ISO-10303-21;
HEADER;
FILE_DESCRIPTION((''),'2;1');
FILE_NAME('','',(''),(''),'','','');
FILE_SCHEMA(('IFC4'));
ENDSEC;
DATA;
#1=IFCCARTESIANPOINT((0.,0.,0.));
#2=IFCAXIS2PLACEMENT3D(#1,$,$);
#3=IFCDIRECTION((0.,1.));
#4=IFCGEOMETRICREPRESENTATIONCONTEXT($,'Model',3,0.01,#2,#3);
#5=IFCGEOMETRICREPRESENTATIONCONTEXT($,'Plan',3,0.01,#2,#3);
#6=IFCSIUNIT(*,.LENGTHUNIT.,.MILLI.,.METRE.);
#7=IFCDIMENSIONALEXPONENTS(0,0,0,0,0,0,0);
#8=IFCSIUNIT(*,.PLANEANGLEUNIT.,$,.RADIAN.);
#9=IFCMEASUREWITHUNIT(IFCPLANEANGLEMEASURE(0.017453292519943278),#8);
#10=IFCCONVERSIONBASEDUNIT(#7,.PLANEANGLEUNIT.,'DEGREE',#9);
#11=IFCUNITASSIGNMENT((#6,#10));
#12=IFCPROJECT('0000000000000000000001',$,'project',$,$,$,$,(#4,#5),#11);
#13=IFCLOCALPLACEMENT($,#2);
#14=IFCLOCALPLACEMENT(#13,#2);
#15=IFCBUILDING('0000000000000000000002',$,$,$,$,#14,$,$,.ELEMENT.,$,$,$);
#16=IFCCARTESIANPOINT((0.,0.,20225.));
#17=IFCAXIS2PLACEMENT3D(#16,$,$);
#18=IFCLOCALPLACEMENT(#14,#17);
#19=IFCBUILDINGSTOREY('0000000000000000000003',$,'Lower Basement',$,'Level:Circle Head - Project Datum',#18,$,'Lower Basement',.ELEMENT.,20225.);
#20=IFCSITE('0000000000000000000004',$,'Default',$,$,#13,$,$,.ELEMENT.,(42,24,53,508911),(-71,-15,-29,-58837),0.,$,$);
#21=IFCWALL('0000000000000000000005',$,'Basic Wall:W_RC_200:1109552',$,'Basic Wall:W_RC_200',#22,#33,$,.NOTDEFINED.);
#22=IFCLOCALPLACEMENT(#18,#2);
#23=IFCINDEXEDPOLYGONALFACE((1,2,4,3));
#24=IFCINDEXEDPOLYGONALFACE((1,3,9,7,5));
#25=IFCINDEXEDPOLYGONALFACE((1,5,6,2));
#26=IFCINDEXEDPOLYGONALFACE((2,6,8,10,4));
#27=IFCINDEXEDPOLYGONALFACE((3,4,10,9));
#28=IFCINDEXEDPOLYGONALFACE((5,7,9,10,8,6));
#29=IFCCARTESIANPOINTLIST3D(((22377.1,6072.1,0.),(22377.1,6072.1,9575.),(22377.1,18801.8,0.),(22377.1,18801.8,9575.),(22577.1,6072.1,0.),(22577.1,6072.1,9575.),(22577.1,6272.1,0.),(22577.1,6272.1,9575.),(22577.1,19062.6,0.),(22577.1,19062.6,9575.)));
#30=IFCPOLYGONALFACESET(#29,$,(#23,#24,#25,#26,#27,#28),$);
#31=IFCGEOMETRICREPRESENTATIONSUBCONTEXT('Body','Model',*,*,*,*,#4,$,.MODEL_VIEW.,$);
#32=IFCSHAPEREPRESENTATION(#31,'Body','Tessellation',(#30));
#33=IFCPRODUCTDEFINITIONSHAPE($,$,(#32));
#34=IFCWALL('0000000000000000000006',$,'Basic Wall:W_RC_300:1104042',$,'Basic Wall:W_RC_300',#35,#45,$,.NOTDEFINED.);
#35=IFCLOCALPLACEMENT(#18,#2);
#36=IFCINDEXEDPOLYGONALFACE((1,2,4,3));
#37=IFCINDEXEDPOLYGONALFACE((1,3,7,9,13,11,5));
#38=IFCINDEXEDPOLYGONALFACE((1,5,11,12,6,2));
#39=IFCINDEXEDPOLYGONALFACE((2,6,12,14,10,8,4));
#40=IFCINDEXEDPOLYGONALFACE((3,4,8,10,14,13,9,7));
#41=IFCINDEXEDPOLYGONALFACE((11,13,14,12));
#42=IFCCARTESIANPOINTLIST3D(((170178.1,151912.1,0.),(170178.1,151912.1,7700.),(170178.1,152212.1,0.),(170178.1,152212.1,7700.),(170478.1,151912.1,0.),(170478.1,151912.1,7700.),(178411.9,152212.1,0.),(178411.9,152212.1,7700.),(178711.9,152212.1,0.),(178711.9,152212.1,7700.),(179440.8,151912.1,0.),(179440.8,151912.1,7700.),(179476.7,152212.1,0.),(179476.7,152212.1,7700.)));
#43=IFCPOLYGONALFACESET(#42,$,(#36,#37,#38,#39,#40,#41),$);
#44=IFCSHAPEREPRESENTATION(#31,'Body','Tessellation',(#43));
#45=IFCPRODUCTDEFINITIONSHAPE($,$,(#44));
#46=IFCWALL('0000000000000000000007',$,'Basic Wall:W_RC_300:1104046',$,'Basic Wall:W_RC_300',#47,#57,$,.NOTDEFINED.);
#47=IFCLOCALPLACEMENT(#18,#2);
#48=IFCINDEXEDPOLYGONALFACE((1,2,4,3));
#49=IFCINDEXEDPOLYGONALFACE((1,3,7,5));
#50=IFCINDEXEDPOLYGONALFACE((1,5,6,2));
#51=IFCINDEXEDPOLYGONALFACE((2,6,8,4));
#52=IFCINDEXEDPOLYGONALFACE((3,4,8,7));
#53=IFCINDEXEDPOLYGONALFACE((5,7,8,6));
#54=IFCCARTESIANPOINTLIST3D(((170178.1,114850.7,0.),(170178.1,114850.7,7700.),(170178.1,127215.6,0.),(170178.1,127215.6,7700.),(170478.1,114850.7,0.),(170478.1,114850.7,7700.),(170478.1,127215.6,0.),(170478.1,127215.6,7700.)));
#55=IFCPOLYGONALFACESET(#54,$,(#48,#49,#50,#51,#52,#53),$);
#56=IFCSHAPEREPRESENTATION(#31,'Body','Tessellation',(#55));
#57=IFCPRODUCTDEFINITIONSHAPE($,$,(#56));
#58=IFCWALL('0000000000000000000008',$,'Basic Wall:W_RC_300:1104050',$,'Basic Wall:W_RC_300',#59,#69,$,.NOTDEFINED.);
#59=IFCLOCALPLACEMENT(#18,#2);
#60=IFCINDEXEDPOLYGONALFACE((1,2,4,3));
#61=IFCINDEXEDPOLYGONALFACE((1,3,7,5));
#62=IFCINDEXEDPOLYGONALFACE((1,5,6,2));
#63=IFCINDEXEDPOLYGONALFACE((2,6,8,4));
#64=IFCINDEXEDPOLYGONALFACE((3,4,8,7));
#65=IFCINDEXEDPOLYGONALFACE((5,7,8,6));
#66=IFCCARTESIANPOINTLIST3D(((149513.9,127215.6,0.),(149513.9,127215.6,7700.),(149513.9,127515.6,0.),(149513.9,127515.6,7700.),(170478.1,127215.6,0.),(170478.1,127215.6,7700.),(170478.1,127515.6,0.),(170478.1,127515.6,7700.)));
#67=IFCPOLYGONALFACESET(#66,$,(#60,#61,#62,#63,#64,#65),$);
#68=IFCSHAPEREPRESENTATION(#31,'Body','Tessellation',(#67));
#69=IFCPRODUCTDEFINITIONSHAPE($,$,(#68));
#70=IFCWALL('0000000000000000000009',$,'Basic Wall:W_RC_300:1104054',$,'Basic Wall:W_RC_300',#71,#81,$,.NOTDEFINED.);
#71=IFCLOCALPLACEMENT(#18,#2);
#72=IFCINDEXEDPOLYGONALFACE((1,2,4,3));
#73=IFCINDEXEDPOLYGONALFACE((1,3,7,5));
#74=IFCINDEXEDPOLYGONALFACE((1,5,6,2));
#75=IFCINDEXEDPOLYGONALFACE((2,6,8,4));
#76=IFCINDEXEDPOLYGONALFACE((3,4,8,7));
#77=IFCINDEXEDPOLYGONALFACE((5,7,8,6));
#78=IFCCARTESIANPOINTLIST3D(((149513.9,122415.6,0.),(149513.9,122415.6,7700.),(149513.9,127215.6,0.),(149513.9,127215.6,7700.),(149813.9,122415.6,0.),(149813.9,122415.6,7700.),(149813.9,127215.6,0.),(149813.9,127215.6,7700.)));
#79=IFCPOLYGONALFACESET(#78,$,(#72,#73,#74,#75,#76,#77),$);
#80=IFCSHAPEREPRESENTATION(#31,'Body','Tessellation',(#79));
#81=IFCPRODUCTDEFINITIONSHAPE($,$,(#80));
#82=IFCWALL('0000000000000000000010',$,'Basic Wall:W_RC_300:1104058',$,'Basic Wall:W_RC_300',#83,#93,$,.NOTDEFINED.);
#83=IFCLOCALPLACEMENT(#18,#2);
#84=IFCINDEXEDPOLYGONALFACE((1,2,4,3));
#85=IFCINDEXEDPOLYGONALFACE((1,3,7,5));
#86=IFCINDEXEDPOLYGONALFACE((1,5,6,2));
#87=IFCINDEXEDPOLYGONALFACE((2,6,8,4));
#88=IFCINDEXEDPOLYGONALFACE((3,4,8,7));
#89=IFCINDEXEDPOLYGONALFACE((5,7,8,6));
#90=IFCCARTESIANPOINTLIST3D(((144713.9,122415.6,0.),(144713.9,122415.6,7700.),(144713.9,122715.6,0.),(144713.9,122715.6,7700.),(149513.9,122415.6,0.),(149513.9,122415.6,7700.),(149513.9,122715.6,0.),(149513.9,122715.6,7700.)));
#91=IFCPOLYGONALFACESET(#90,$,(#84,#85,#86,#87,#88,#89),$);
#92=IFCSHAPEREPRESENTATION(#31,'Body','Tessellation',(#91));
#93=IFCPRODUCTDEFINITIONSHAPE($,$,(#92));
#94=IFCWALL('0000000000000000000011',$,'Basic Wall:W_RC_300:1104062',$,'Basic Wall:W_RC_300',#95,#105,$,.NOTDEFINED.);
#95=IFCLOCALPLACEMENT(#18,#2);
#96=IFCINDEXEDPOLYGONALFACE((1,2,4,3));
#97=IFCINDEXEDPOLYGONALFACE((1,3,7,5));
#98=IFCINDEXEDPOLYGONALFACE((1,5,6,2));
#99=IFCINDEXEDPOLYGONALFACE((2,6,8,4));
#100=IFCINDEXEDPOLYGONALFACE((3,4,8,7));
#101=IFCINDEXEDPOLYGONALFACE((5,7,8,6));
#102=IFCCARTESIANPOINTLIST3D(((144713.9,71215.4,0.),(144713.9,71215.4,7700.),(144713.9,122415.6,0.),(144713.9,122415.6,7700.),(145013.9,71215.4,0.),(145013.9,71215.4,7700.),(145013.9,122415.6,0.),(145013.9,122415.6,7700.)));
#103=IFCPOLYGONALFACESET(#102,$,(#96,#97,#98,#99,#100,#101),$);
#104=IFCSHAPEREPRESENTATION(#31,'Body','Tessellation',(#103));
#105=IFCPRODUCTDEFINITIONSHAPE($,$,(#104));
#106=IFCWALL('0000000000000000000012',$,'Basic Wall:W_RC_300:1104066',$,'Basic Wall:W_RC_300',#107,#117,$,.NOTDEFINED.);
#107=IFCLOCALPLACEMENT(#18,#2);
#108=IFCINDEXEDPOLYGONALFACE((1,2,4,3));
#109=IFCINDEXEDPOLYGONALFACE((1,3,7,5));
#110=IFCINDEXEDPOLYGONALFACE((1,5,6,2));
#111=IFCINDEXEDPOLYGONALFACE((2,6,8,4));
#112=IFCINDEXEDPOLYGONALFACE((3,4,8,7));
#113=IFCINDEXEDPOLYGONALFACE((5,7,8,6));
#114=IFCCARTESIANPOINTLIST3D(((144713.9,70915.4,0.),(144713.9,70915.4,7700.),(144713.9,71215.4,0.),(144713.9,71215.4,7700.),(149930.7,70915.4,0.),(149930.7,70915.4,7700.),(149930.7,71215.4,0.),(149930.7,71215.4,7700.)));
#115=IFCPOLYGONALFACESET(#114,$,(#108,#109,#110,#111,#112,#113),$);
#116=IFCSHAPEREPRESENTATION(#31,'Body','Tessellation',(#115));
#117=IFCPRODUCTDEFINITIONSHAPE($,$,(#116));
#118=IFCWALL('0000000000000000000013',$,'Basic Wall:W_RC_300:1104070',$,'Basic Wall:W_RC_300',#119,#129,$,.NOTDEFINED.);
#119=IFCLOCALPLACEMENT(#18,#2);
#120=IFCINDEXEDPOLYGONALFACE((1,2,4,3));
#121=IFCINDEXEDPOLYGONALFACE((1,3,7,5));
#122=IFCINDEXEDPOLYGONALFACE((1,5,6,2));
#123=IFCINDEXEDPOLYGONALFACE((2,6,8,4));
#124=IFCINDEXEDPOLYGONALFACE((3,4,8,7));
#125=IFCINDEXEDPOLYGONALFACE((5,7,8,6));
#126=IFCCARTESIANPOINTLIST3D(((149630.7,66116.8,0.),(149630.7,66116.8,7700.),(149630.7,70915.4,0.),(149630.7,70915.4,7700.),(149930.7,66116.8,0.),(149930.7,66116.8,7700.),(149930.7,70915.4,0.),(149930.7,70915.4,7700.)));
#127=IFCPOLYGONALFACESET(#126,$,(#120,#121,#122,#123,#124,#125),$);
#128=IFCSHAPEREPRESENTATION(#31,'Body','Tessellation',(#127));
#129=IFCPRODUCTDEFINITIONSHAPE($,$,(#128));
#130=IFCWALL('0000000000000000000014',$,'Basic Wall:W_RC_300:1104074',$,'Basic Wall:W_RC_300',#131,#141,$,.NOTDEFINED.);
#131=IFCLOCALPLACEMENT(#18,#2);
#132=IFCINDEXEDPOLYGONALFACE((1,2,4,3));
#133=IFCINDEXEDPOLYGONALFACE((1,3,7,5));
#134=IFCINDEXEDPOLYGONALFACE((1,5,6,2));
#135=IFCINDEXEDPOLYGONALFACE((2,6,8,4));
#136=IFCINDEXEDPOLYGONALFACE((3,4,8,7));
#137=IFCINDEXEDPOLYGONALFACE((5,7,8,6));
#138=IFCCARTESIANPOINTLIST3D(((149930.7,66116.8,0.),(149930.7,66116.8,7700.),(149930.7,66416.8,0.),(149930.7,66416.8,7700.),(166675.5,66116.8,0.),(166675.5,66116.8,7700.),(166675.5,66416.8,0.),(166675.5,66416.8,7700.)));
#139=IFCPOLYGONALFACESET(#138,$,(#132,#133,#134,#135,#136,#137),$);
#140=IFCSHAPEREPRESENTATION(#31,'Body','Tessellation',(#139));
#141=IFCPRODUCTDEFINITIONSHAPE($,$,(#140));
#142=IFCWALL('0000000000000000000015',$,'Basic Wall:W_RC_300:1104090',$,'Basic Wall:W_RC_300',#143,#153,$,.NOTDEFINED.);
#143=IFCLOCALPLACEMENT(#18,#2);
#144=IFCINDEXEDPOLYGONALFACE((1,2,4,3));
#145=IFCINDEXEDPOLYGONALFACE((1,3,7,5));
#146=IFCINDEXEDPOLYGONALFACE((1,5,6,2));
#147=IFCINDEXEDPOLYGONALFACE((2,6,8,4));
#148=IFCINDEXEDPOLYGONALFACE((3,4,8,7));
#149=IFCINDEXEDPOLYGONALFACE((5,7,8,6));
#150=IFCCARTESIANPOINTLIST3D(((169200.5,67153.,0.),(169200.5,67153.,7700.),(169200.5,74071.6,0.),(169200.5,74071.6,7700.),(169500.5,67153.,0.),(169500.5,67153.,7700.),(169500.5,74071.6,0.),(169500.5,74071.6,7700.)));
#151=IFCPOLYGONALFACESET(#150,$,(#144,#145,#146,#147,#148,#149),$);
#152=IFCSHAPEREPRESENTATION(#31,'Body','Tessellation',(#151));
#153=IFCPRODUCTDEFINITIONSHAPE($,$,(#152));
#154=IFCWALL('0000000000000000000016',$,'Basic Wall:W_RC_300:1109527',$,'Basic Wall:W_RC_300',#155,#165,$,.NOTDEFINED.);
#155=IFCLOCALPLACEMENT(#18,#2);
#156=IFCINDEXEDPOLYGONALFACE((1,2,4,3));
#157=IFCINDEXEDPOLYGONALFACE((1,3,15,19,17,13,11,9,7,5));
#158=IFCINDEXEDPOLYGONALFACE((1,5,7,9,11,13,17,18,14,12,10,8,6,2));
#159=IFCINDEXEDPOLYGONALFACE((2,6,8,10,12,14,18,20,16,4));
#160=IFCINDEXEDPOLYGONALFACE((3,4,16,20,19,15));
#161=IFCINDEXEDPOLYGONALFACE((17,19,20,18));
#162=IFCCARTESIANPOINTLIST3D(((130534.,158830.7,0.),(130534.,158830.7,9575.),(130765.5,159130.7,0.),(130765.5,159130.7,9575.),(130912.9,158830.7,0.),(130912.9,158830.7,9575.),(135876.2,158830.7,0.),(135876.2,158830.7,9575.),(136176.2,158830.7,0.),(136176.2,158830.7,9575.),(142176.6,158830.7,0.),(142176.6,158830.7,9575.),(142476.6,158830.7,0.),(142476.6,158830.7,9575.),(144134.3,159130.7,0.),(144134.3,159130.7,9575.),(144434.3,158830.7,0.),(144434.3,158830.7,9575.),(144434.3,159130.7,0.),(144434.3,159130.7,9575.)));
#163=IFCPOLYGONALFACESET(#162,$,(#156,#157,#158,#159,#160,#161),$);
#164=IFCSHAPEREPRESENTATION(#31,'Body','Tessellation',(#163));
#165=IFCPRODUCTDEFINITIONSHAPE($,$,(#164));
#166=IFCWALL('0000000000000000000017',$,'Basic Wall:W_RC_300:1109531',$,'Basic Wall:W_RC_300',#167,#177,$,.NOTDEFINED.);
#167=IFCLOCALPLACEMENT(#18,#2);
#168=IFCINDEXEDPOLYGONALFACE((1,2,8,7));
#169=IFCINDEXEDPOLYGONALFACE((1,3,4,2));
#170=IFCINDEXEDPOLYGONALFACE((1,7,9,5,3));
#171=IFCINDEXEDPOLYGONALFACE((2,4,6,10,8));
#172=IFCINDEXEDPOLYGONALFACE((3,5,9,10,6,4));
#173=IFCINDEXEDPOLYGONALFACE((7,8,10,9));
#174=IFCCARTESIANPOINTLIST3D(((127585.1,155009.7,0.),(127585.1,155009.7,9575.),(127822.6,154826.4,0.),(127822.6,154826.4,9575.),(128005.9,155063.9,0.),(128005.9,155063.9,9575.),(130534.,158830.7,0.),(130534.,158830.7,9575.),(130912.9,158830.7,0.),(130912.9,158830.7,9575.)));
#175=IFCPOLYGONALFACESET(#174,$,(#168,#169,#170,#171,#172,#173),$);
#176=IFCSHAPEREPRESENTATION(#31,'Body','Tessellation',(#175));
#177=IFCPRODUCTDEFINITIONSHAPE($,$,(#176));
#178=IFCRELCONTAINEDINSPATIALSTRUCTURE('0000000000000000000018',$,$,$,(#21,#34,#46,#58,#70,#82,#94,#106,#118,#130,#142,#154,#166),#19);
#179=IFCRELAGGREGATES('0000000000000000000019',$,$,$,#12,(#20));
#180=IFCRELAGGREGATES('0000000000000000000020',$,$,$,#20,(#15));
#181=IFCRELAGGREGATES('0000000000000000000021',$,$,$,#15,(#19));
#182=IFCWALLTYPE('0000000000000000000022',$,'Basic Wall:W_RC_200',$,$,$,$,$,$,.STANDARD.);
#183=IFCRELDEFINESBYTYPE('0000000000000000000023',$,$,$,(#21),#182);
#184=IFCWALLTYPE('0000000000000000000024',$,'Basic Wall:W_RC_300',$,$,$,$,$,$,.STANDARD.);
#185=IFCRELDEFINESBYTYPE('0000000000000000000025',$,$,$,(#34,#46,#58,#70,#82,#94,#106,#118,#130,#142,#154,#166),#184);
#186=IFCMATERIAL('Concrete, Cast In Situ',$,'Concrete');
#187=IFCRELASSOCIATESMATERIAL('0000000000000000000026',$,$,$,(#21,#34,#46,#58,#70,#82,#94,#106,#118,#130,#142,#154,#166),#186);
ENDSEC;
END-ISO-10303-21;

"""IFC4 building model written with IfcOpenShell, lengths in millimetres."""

from ifc_helpers import new_model, entity, si_unit, converted_unit, direction, frame, origin, place, context, subcontext, project, spatial, indexed_curve, outline, extrude, material, type_object, element, save


model = new_model("IFC4")

# Units and contexts
model_context = context("Model", 3, precision=0.01, world=origin(), true_north=direction((0.0, 1.0)))
plan_context = context("Plan", 3, precision=0.01, world=origin(), true_north=direction((0.0, 1.0)))
body_context = subcontext(model_context, "Body", "Model", "MODEL_VIEW")
ifc_project = project(units=[si_unit("LENGTHUNIT", "METRE", prefix="MILLI"), converted_unit("PLANEANGLEUNIT", "DEGREE", entity("IfcPlaneAngleMeasure", 0.017453292519943278), si_unit("PLANEANGLEUNIT", "RADIAN"), dimensions=[0, 0, 0, 0, 0, 0, 0])], contexts=[model_context, plan_context])

# Site, building, storey
site_placement = place(None, origin())
site = spatial("IfcSite", under=ifc_project, at=site_placement, Name="Default", CompositionType="ELEMENT", RefLatitude=(42, 24, 53, 508911), RefLongitude=(-71, -15, -29, -58837), RefElevation=0.0)
building_placement = place(site_placement, origin())
building = spatial("IfcBuilding", under=site, at=building_placement, CompositionType="ELEMENT")
storey_placement = place(building_placement, frame((0.0, 0.0, 20225.0)))
storey = spatial("IfcBuildingStorey", under=building, at=storey_placement, Name="Lower Basement", ObjectType="Level:Circle Head - Project Datum", LongName="Lower Basement", CompositionType="ELEMENT", Elevation=20225.0)

# Walls
ifc_material_1 = material(Name="Concrete, Cast In Situ", Category="Concrete")
wall_type_1 = type_object("IfcWallType", Name="Basic Wall:W_RC_200", PredefinedType="STANDARD")
wall_1_placement = place(storey_placement, frame((22477.1, 19062.6, 0.0), z_axis=(0.0, 0.0, 1.0), x_axis=(0.0, -1.0, 0.0)))
element("IfcWall", 1, at=wall_1_placement, inside=storey, type_object=wall_type_1, material=ifc_material_1, Name="Basic Wall:W_RC_200:1109552", ObjectType="Basic Wall:W_RC_200", PredefinedType="NOTDEFINED", context=body_context, shape_type="SweptSolid", body=[
    extrude(outline(indexed_curve([(12990.5, -100.0), (12990.5, 100.0), (12790.5, 100.0), (0.0, 100.0), (260.8, -100.0), (12990.5, -100.0)], self_intersect=False)), origin(), (0.0, 0.0, 1.0), 9575.0),
])
wall_type_2 = type_object("IfcWallType", Name="Basic Wall:W_RC_300", PredefinedType="STANDARD")
wall_2_placement = place(storey_placement, frame((170178.1, 152062.1, 0.0)))
element("IfcWall", 2, at=wall_2_placement, inside=storey, type_object=wall_type_2, material=ifc_material_1, Name="Basic Wall:W_RC_300:1104042", ObjectType="Basic Wall:W_RC_300", PredefinedType="NOTDEFINED", context=body_context, shape_type="SweptSolid", body=[
    extrude(outline(indexed_curve([(9262.7, -150.0), (9298.6, 150.0), (8533.8, 150.0), (8233.8, 150.0), (0.0, 150.0), (0.0, -150.0), (300.0, -150.0), (9262.7, -150.0)], self_intersect=False)), origin(), (0.0, 0.0, 1.0), 7700.0),
])
wall_3_placement = place(storey_placement, frame((170328.1, 114850.7, 0.0), z_axis=(0.0, 0.0, 1.0), x_axis=(0.0, 1.0, 0.0)))
element("IfcWall", 3, at=wall_3_placement, inside=storey, type_object=wall_type_2, material=ifc_material_1, Name="Basic Wall:W_RC_300:1104046", ObjectType="Basic Wall:W_RC_300", PredefinedType="NOTDEFINED", context=body_context, shape_type="SweptSolid", body=[
    extrude(outline(indexed_curve([(12364.9, 150.0), (0.0, 150.0), (0.0, -150.0), (12364.9, -150.0), (12364.9, 150.0)], self_intersect=False)), origin(), (0.0, 0.0, 1.0), 7700.0),
])
wall_4_placement = place(storey_placement, frame((149513.9, 127365.6, 0.0)))
element("IfcWall", 4, at=wall_4_placement, inside=storey, type_object=wall_type_2, material=ifc_material_1, Name="Basic Wall:W_RC_300:1104050", ObjectType="Basic Wall:W_RC_300", PredefinedType="NOTDEFINED", context=body_context, shape_type="SweptSolid", body=[
    extrude(outline(indexed_curve([(20964.2, 150.0), (0.0, 150.0), (0.0, -150.0), (20964.2, -150.0), (20964.2, 150.0)], self_intersect=False)), origin(), (0.0, 0.0, 1.0), 7700.0),
])
wall_5_placement = place(storey_placement, frame((149663.9, 122415.6, 0.0), z_axis=(0.0, 0.0, 1.0), x_axis=(0.0, 1.0, 0.0)))
element("IfcWall", 5, at=wall_5_placement, inside=storey, type_object=wall_type_2, material=ifc_material_1, Name="Basic Wall:W_RC_300:1104054", ObjectType="Basic Wall:W_RC_300", PredefinedType="NOTDEFINED", context=body_context, shape_type="SweptSolid", body=[
    extrude(outline(indexed_curve([(4800.0, 150.0), (0.0, 150.0), (0.0, -150.0), (4800.0, -150.0), (4800.0, 150.0)], self_intersect=False)), origin(), (0.0, 0.0, 1.0), 7700.0),
])
wall_6_placement = place(storey_placement, frame((144713.9, 122565.6, 0.0)))
element("IfcWall", 6, at=wall_6_placement, inside=storey, type_object=wall_type_2, material=ifc_material_1, Name="Basic Wall:W_RC_300:1104058", ObjectType="Basic Wall:W_RC_300", PredefinedType="NOTDEFINED", context=body_context, shape_type="SweptSolid", body=[
    extrude(outline(indexed_curve([(4800.0, 150.0), (0.0, 150.0), (0.0, -150.0), (4800.0, -150.0), (4800.0, 150.0)], self_intersect=False)), origin(), (0.0, 0.0, 1.0), 7700.0),
])
wall_7_placement = place(storey_placement, frame((144863.9, 71215.4, 0.0), z_axis=(0.0, 0.0, 1.0), x_axis=(0.0, 1.0, 0.0)))
element("IfcWall", 7, at=wall_7_placement, inside=storey, type_object=wall_type_2, material=ifc_material_1, Name="Basic Wall:W_RC_300:1104062", ObjectType="Basic Wall:W_RC_300", PredefinedType="NOTDEFINED", context=body_context, shape_type="SweptSolid", body=[
    extrude(outline(indexed_curve([(51200.2, 150.0), (0.0, 150.0), (0.0, -150.0), (51200.2, -150.0), (51200.2, 150.0)], self_intersect=False)), origin(), (0.0, 0.0, 1.0), 7700.0),
])
wall_8_placement = place(storey_placement, frame((149930.7, 71065.4, 0.0), z_axis=(0.0, 0.0, 1.0), x_axis=(-1.0, 0.0, 0.0)))
element("IfcWall", 8, at=wall_8_placement, inside=storey, type_object=wall_type_2, material=ifc_material_1, Name="Basic Wall:W_RC_300:1104066", ObjectType="Basic Wall:W_RC_300", PredefinedType="NOTDEFINED", context=body_context, shape_type="SweptSolid", body=[
    extrude(outline(indexed_curve([(5216.7, 150.0), (0.0, 150.0), (0.0, -150.0), (5216.7, -150.0), (5216.7, 150.0)], self_intersect=False)), origin(), (0.0, 0.0, 1.0), 7700.0),
])
wall_9_placement = place(storey_placement, frame((149780.7, 66116.8, 0.0), z_axis=(0.0, 0.0, 1.0), x_axis=(0.0, 1.0, 0.0)))
element("IfcWall", 9, at=wall_9_placement, inside=storey, type_object=wall_type_2, material=ifc_material_1, Name="Basic Wall:W_RC_300:1104070", ObjectType="Basic Wall:W_RC_300", PredefinedType="NOTDEFINED", context=body_context, shape_type="SweptSolid", body=[
    extrude(outline(indexed_curve([(4798.6, 150.0), (0.0, 150.0), (0.0, -150.0), (4798.6, -150.0), (4798.6, 150.0)], self_intersect=False)), origin(), (0.0, 0.0, 1.0), 7700.0),
])
wall_10_placement = place(storey_placement, frame((166675.5, 66266.8, 0.0), z_axis=(0.0, 0.0, 1.0), x_axis=(-1.0, 0.0, 0.0)))
element("IfcWall", 10, at=wall_10_placement, inside=storey, type_object=wall_type_2, material=ifc_material_1, Name="Basic Wall:W_RC_300:1104074", ObjectType="Basic Wall:W_RC_300", PredefinedType="NOTDEFINED", context=body_context, shape_type="SweptSolid", body=[
    extrude(outline(indexed_curve([(16744.8, 150.0), (0.0, 150.0), (0.0, -150.0), (16744.8, -150.0), (16744.8, 150.0)], self_intersect=False)), origin(), (0.0, 0.0, 1.0), 7700.0),
])
wall_11_placement = place(storey_placement, frame((169350.5, 74071.6, 0.0), z_axis=(0.0, 0.0, 1.0), x_axis=(0.0, -1.0, 0.0)))
element("IfcWall", 11, at=wall_11_placement, inside=storey, type_object=wall_type_2, material=ifc_material_1, Name="Basic Wall:W_RC_300:1104090", ObjectType="Basic Wall:W_RC_300", PredefinedType="NOTDEFINED", context=body_context, shape_type="SweptSolid", body=[
    extrude(outline(indexed_curve([(6918.6, 150.0), (0.0, 150.0), (0.0, -150.0), (6918.6, -150.0), (6918.6, 150.0)], self_intersect=False)), origin(), (0.0, 0.0, 1.0), 7700.0),
])
wall_12_placement = place(storey_placement, frame((130534.0, 158980.7, 0.0)))
element("IfcWall", 12, at=wall_12_placement, inside=storey, type_object=wall_type_2, material=ifc_material_1, Name="Basic Wall:W_RC_300:1109527", ObjectType="Basic Wall:W_RC_300", PredefinedType="NOTDEFINED", context=body_context, shape_type="SweptSolid", body=[
    extrude(outline(indexed_curve([(13900.3, -150.0), (13900.3, 150.0), (13600.3, 150.0), (231.5, 150.0), (0.0, -150.0), (378.9, -150.0), (5342.2, -150.0), (5642.2, -150.0), (11642.6, -150.0), (11942.6, -150.0), (13900.3, -150.0)], self_intersect=False)), origin(), (0.0, 0.0, 1.0), 9575.0),
])
wall_13_placement = place(storey_placement, frame((127703.9, 154918.0, 0.0), z_axis=(0.0, 0.0, 1.0), x_axis=(0.610952, 0.791667, 0.0)))
element("IfcWall", 13, at=wall_13_placement, inside=storey, type_object=wall_type_2, material=ifc_material_1, Name="Basic Wall:W_RC_300:1109531", ObjectType="Basic Wall:W_RC_300", PredefinedType="NOTDEFINED", context=body_context, shape_type="SweptSolid", body=[
    extrude(outline(indexed_curve([(5058.1, -150.0), (4826.6, 150.0), (0.0, 150.0), (0.0, -150.0), (300.0, -150.0), (5058.1, -150.0)], self_intersect=False)), origin(), (0.0, 0.0, 1.0), 9575.0),
])

save(model, "model.ifc")
